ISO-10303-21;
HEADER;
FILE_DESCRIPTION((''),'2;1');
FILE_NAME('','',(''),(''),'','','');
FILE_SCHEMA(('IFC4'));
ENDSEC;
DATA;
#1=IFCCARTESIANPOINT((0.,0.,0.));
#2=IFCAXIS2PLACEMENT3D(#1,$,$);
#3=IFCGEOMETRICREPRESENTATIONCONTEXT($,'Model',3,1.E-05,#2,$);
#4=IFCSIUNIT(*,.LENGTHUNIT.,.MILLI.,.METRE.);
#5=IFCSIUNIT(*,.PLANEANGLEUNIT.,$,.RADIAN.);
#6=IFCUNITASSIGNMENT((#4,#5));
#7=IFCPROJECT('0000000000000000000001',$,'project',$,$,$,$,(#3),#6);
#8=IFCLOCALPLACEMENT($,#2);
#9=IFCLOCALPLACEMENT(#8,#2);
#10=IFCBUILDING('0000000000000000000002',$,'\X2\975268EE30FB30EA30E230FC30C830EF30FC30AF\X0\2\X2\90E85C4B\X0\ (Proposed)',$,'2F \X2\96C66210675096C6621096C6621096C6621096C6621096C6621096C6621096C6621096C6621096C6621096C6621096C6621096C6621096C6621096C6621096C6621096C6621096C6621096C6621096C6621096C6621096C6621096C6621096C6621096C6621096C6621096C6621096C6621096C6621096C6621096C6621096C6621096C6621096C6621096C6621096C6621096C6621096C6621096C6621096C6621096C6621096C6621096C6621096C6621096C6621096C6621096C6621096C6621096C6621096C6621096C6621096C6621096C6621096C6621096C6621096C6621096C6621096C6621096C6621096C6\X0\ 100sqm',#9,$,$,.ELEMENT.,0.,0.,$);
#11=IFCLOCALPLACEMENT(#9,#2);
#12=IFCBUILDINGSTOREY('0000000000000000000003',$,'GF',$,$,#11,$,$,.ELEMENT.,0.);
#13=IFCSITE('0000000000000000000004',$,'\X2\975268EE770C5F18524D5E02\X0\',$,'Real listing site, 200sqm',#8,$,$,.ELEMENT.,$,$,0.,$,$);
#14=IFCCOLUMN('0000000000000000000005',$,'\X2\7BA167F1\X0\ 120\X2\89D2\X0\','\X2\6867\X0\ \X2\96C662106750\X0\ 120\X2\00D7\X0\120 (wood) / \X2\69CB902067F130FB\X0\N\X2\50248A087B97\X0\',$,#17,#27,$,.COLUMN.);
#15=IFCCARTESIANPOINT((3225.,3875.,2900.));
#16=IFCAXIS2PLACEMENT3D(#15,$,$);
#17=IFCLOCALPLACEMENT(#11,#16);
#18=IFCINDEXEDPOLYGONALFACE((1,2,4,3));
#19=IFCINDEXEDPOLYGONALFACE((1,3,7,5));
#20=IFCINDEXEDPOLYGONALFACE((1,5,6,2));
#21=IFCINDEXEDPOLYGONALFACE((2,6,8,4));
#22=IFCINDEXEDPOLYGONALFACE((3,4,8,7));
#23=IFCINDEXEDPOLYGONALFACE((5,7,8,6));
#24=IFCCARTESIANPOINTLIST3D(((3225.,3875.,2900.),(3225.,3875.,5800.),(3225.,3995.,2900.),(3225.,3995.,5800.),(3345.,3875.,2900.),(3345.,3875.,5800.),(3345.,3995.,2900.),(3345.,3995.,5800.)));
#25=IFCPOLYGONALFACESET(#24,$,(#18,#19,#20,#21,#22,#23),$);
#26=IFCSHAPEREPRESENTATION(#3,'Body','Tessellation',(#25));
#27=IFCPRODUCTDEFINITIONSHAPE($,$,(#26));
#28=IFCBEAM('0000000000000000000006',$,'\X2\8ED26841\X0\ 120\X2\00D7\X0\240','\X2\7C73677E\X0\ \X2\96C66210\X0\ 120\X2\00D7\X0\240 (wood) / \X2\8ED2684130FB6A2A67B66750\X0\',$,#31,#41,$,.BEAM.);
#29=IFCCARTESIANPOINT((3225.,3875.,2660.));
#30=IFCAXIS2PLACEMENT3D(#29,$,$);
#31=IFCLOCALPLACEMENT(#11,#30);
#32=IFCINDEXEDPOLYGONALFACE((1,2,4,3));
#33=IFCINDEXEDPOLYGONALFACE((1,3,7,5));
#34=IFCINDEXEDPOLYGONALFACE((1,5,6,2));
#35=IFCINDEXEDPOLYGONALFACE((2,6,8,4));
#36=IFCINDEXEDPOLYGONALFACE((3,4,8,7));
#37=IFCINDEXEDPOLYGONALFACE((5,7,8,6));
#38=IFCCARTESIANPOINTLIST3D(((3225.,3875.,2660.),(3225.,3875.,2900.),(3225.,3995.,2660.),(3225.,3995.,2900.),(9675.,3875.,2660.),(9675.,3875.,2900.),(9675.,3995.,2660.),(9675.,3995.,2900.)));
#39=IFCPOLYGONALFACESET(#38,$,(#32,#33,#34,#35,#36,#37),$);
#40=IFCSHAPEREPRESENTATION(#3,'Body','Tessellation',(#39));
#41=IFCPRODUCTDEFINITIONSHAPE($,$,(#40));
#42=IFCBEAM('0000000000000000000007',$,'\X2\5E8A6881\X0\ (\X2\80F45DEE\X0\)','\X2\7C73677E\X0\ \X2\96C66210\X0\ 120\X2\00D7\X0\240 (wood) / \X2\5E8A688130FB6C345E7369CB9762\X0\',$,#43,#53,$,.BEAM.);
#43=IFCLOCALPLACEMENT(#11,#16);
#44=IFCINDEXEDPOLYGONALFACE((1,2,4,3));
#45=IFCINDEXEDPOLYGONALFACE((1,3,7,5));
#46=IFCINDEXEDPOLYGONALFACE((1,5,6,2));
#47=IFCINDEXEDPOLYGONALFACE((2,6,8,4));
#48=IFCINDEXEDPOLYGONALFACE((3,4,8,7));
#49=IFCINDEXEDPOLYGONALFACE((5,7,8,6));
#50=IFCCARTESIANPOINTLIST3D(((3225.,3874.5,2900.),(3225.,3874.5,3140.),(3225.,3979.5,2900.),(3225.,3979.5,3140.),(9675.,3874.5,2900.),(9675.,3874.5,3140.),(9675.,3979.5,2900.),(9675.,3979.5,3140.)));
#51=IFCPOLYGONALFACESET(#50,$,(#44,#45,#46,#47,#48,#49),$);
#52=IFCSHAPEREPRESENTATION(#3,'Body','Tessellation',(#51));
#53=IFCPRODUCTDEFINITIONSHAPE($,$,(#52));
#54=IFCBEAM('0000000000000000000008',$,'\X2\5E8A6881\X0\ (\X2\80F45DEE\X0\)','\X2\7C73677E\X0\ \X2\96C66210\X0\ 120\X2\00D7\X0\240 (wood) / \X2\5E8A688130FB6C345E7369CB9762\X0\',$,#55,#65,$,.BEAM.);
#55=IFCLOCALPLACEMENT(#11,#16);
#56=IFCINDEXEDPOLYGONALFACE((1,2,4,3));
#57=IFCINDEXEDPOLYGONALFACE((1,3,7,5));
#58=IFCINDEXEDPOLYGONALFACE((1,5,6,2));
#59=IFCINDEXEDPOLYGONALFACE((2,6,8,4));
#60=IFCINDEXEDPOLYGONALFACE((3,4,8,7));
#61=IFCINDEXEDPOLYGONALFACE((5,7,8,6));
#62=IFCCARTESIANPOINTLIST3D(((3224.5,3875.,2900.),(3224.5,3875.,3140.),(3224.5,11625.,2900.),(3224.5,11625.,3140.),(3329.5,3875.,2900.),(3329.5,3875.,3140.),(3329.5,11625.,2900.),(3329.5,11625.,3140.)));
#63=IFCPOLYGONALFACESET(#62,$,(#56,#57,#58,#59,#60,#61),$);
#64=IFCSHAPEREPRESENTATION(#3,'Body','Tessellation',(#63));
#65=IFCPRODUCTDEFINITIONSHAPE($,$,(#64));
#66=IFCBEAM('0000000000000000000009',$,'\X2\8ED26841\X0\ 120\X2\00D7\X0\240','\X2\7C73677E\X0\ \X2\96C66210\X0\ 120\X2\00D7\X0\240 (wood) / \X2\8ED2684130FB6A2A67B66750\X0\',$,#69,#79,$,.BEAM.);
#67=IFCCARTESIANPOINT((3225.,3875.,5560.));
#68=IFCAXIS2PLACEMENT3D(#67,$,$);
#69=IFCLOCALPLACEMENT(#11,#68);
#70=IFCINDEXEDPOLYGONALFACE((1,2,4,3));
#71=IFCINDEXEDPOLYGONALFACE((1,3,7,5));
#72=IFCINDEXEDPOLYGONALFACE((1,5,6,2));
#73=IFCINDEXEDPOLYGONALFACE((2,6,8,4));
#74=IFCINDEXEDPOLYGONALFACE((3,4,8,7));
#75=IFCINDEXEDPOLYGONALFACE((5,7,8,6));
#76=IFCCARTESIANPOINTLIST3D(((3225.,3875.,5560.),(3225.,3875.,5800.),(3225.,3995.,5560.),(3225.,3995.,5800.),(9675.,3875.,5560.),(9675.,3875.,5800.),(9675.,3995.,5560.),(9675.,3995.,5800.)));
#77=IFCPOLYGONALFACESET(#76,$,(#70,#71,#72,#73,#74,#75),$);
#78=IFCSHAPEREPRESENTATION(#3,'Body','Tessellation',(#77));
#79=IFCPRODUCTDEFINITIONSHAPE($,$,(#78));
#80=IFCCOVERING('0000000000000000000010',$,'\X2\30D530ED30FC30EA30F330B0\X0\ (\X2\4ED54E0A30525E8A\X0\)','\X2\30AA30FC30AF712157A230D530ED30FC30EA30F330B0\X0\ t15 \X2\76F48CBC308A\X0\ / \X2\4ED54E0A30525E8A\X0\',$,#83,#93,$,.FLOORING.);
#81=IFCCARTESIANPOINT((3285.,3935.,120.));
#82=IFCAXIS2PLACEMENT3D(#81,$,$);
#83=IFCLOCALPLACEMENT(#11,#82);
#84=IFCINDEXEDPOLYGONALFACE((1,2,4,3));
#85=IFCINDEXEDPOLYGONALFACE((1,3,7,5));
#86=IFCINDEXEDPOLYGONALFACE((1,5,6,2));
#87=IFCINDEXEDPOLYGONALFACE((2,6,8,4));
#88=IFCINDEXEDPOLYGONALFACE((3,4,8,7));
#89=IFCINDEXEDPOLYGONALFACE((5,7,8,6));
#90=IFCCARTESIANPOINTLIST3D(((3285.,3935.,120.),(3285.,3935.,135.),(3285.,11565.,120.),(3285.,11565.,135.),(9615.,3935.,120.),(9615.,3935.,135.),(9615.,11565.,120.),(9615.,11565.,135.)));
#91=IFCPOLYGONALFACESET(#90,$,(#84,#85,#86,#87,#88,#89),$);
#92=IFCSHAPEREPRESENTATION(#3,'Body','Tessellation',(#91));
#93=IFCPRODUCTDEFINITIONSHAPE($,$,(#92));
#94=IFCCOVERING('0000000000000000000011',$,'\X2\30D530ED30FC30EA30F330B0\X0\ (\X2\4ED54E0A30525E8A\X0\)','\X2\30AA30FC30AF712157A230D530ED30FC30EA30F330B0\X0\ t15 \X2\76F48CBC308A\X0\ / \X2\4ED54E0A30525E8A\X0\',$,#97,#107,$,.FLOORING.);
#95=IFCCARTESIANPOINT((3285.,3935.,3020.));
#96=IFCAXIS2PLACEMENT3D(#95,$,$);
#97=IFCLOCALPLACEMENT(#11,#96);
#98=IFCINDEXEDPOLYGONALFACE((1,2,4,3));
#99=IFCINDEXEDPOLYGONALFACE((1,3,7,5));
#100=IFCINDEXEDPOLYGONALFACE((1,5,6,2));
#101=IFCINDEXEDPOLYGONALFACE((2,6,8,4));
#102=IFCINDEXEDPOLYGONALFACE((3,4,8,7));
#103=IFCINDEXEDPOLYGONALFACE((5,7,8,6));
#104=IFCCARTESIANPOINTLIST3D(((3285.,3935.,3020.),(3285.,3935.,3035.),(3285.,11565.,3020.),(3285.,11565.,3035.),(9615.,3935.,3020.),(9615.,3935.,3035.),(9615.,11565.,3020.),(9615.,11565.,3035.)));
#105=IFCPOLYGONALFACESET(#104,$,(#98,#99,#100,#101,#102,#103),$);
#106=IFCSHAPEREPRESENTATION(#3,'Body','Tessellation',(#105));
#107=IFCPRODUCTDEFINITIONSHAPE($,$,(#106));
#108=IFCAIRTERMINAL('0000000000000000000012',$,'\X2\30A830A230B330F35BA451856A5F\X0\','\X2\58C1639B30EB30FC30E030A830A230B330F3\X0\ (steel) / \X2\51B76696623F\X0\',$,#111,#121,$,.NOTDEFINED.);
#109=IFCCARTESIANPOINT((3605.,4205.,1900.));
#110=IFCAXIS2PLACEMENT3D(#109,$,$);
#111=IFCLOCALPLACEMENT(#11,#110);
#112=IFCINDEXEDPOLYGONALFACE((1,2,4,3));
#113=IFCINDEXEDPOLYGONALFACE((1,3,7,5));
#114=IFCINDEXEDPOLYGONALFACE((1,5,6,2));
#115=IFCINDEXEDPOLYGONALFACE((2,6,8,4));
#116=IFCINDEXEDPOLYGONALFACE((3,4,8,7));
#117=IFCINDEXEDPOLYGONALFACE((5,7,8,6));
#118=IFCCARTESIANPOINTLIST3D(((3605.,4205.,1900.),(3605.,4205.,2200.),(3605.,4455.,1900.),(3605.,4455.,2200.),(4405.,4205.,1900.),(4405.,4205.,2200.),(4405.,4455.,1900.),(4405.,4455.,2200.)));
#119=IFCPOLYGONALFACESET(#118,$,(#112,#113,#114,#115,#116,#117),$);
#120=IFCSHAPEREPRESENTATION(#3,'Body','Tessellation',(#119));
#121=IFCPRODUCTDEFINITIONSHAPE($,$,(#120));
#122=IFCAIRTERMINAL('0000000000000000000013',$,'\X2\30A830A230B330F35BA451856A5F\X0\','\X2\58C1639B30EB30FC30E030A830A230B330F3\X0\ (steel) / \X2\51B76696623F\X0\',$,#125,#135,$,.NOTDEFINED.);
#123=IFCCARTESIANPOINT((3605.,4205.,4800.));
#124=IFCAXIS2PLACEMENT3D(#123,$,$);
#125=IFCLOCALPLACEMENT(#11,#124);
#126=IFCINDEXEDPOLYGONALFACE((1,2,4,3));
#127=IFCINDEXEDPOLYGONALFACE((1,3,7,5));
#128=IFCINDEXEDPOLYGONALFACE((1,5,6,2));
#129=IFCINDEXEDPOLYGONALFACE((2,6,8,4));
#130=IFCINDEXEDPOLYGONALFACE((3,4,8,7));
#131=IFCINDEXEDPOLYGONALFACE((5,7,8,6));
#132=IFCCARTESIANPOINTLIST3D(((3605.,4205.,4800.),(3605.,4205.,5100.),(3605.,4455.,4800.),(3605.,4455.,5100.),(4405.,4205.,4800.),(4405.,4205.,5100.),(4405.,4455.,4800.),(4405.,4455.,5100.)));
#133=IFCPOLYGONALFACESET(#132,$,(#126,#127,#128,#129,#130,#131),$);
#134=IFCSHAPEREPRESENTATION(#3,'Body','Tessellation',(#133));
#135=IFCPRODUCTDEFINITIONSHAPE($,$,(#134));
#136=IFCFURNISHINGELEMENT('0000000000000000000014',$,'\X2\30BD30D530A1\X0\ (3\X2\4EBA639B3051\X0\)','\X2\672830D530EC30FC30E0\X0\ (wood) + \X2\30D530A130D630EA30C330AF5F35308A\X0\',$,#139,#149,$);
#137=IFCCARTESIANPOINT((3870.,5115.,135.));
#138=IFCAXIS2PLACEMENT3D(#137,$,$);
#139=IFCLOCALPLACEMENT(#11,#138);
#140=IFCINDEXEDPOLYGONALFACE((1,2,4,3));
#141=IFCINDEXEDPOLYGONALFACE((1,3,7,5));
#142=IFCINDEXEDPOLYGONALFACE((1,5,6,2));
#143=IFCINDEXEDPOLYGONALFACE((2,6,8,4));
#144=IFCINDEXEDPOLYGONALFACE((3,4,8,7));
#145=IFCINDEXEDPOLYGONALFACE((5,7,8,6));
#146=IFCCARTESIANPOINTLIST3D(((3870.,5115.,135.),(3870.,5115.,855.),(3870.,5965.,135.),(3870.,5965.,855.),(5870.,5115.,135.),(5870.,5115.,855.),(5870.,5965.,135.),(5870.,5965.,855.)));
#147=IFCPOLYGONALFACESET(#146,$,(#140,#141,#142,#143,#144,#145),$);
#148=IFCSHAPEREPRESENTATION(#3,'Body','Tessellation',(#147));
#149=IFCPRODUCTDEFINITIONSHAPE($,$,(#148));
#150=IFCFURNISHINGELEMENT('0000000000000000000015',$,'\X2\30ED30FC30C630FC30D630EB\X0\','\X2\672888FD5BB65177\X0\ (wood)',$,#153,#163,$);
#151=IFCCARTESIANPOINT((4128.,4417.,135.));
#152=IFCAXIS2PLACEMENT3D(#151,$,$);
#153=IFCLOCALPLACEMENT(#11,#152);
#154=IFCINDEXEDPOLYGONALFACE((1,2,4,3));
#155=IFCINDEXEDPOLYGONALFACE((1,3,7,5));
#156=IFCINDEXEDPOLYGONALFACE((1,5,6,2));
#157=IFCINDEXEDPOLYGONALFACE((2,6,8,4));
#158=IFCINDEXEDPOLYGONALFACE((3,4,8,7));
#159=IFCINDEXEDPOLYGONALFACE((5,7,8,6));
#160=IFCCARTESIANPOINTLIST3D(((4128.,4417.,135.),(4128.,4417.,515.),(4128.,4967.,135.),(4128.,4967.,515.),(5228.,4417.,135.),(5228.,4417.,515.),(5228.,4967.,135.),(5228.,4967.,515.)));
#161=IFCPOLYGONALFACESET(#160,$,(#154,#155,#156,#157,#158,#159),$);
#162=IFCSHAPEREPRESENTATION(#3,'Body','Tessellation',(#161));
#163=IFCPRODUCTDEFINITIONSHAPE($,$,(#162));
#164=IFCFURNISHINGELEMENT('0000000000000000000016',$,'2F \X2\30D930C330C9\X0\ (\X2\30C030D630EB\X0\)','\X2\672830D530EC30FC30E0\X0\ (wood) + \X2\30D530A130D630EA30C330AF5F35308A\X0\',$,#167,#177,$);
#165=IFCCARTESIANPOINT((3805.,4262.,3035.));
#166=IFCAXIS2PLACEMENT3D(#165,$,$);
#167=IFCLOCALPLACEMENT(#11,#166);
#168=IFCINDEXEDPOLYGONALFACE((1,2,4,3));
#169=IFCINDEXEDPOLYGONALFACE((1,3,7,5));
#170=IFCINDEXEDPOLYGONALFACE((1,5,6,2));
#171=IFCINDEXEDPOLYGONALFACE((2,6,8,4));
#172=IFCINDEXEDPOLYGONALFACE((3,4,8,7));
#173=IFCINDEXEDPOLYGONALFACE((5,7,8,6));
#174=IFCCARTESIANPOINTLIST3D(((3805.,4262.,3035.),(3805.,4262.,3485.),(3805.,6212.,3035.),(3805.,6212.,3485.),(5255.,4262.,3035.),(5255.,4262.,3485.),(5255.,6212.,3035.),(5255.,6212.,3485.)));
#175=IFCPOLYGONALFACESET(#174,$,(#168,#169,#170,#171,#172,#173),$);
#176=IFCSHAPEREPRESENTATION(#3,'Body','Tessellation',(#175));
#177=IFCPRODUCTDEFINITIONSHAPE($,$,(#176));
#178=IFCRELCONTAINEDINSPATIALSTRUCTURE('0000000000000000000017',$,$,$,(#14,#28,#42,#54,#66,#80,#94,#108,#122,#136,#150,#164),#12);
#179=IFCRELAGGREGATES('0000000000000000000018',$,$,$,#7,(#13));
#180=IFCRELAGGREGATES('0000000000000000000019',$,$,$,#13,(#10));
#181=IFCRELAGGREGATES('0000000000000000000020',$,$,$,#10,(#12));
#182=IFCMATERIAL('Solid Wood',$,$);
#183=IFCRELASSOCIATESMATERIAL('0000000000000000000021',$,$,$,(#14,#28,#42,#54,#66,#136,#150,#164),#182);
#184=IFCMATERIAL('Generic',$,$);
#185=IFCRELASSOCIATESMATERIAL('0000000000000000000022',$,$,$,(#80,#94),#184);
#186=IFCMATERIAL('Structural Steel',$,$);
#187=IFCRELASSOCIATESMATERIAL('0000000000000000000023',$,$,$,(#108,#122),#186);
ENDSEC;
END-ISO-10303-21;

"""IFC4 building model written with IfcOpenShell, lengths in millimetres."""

from ifc_helpers import new_model, si_unit, frame, frame_2d, origin, place, context, project, spatial, rectangle, extrude, material, element, save


model = new_model("IFC4")

# Units and contexts
model_context = context("Model", 3, precision=1e-05, world=origin())
ifc_project = project(units=[si_unit("LENGTHUNIT", "METRE", prefix="MILLI"), si_unit("PLANEANGLEUNIT", "RADIAN")], contexts=[model_context])

# Site, building, storey
site_placement = place(None, origin())
site = spatial("IfcSite", under=ifc_project, at=site_placement, Name="青森県弘前市", ObjectType="Real listing site, 200sqm", CompositionType="ELEMENT", RefElevation=0.0)
building_placement = place(site_placement, origin())
building = spatial("IfcBuilding", under=site, at=building_placement, Name="青森・リモートワーク2部屋 (Proposed)", ObjectType="2F 集成材集成集成集成集成集成集成集成集成集成集成集成集成集成集成集成集成集成集成集成集成集成集成集成集成集成集成集成集成集成集成集成集成集成集成集成集成集成集成集成集成集成集成集成集成集成集成集成集成集成集成集成集成集成集成集成集成集成集成集 100sqm", CompositionType="ELEMENT", ElevationOfRefHeight=0.0, ElevationOfTerrain=0.0)
storey_placement = place(building_placement, origin())
storey = spatial("IfcBuildingStorey", under=building, at=storey_placement, Name="GF", CompositionType="ELEMENT", Elevation=0.0)

# Column
ifc_material_1 = material(Name="Solid Wood")
column_placement = place(storey_placement, frame((3225.0, 3875.0, 2900.0)))
element("IfcColumn", 1, at=column_placement, inside=storey, material=ifc_material_1, Name="管柱 120角", Description="桧 集成材 120×120 (wood) / 構造柱・N値計算", PredefinedType="COLUMN", context=model_context, shape_type="SweptSolid", body=[
    extrude(rectangle(XDim=120.0, YDim=120.0, at=frame_2d((60.0, 60.0))), frame((3225.0, 3875.0, 2900.0)), (0.0, 0.0, 1.0), 2900.0),
])

# Beams
beam_1_placement = place(storey_placement, frame((3225.0, 3875.0, 2660.0)))
element("IfcBeam", 2, at=beam_1_placement, inside=storey, material=ifc_material_1, Name="軒桁 120×240", Description="米松 集成 120×240 (wood) / 軒桁・横架材", PredefinedType="BEAM", context=model_context, shape_type="SweptSolid", body=[
    extrude(rectangle(XDim=6450.0, YDim=120.0, at=frame_2d((3225.0, 60.0))), frame((3225.0, 3875.0, 2660.0)), (0.0, 0.0, 1.0), 240.0),
])
beam_2_placement = place(storey_placement, frame((3225.0, 3875.0, 2900.0)))
element("IfcBeam", 3, at=beam_2_placement, inside=storey, material=ifc_material_1, Name="床梁 (胴差)", Description="米松 集成 120×240 (wood) / 床梁・水平構面", PredefinedType="BEAM", context=model_context, shape_type="SweptSolid", body=[
    extrude(rectangle(XDim=6450.0, YDim=105.0, at=frame_2d((3225.0, 52.0))), frame((3225.0, 3875.0, 2900.0)), (0.0, 0.0, 1.0), 240.0),
])
beam_3_placement = place(storey_placement, frame((3225.0, 3875.0, 2900.0)))
element("IfcBeam", 4, at=beam_3_placement, inside=storey, material=ifc_material_1, Name="床梁 (胴差)", Description="米松 集成 120×240 (wood) / 床梁・水平構面", PredefinedType="BEAM", context=model_context, shape_type="SweptSolid", body=[
    extrude(rectangle(XDim=105.0, YDim=7750.0, at=frame_2d((52.0, 3875.0))), frame((3225.0, 3875.0, 2900.0)), (0.0, 0.0, 1.0), 240.0),
])
beam_4_placement = place(storey_placement, frame((3225.0, 3875.0, 5560.0)))
element("IfcBeam", 5, at=beam_4_placement, inside=storey, material=ifc_material_1, Name="軒桁 120×240", Description="米松 集成 120×240 (wood) / 軒桁・横架材", PredefinedType="BEAM", context=model_context, shape_type="SweptSolid", body=[
    extrude(rectangle(XDim=6450.0, YDim=120.0, at=frame_2d((3225.0, 60.0))), frame((3225.0, 3875.0, 5560.0)), (0.0, 0.0, 1.0), 240.0),
])

# Coverings
ifc_material_2 = material(Name="Generic")
covering_1_placement = place(storey_placement, frame((3285.0, 3935.0, 120.0)))
element("IfcCovering", 6, at=covering_1_placement, inside=storey, material=ifc_material_2, Name="フローリング (仕上げ床)", Description="オーク無垢フローリング t15 直貼り / 仕上げ床", PredefinedType="FLOORING", context=model_context, shape_type="SweptSolid", body=[
    extrude(rectangle(XDim=6330.0, YDim=7630.0, at=frame_2d((3165.0, 3815.0))), frame((3285.0, 3935.0, 120.0)), (0.0, 0.0, 1.0), 15.0),
])
covering_2_placement = place(storey_placement, frame((3285.0, 3935.0, 3020.0)))
element("IfcCovering", 7, at=covering_2_placement, inside=storey, material=ifc_material_2, Name="フローリング (仕上げ床)", Description="オーク無垢フローリング t15 直貼り / 仕上げ床", PredefinedType="FLOORING", context=model_context, shape_type="SweptSolid", body=[
    extrude(rectangle(XDim=6330.0, YDim=7630.0, at=frame_2d((3165.0, 3815.0))), frame((3285.0, 3935.0, 3020.0)), (0.0, 0.0, 1.0), 15.0),
])

# Air terminals
ifc_material_3 = material(Name="Structural Steel")
air_terminal_1_placement = place(storey_placement, frame((3605.0, 4205.0, 1900.0)))
element("IfcAirTerminal", 8, at=air_terminal_1_placement, inside=storey, material=ifc_material_3, Name="エアコン室内機", Description="壁掛ルームエアコン (steel) / 冷暖房", PredefinedType="NOTDEFINED", context=model_context, shape_type="SweptSolid", body=[
    extrude(rectangle(XDim=800.0, YDim=250.0, at=frame_2d((400.0, 125.0))), frame((3605.0, 4205.0, 1900.0)), (0.0, 0.0, 1.0), 300.0),
])
air_terminal_2_placement = place(storey_placement, frame((3605.0, 4205.0, 4800.0)))
element("IfcAirTerminal", 9, at=air_terminal_2_placement, inside=storey, material=ifc_material_3, Name="エアコン室内機", Description="壁掛ルームエアコン (steel) / 冷暖房", PredefinedType="NOTDEFINED", context=model_context, shape_type="SweptSolid", body=[
    extrude(rectangle(XDim=800.0, YDim=250.0, at=frame_2d((400.0, 125.0))), frame((3605.0, 4205.0, 4800.0)), (0.0, 0.0, 1.0), 300.0),
])

# Furnishing elements
furnishing_1_placement = place(storey_placement, frame((3870.0, 5115.0, 135.0)))
element("IfcFurnishingElement", 10, at=furnishing_1_placement, inside=storey, material=ifc_material_1, Name="ソファ (3人掛け)", Description="木フレーム (wood) + ファブリック張り", context=model_context, shape_type="SweptSolid", body=[
    extrude(rectangle(XDim=2000.0, YDim=850.0, at=frame_2d((1000.0, 425.0))), frame((3870.0, 5115.0, 135.0)), (0.0, 0.0, 1.0), 720.0),
])
furnishing_2_placement = place(storey_placement, frame((4128.0, 4417.0, 135.0)))
element("IfcFurnishingElement", 11, at=furnishing_2_placement, inside=storey, material=ifc_material_1, Name="ローテーブル", Description="木製家具 (wood)", context=model_context, shape_type="SweptSolid", body=[
    extrude(rectangle(XDim=1100.0, YDim=550.0, at=frame_2d((550.0, 275.0))), frame((4128.0, 4417.0, 135.0)), (0.0, 0.0, 1.0), 380.0),
])
furnishing_3_placement = place(storey_placement, frame((3805.0, 4262.0, 3035.0)))
element("IfcFurnishingElement", 12, at=furnishing_3_placement, inside=storey, material=ifc_material_1, Name="2F ベッド (ダブル)", Description="木フレーム (wood) + ファブリック張り", context=model_context, shape_type="SweptSolid", body=[
    extrude(rectangle(XDim=1450.0, YDim=1950.0, at=frame_2d((725.0, 975.0))), frame((3805.0, 4262.0, 3035.0)), (0.0, 0.0, 1.0), 450.0),
])

save(model, "model.ifc")
